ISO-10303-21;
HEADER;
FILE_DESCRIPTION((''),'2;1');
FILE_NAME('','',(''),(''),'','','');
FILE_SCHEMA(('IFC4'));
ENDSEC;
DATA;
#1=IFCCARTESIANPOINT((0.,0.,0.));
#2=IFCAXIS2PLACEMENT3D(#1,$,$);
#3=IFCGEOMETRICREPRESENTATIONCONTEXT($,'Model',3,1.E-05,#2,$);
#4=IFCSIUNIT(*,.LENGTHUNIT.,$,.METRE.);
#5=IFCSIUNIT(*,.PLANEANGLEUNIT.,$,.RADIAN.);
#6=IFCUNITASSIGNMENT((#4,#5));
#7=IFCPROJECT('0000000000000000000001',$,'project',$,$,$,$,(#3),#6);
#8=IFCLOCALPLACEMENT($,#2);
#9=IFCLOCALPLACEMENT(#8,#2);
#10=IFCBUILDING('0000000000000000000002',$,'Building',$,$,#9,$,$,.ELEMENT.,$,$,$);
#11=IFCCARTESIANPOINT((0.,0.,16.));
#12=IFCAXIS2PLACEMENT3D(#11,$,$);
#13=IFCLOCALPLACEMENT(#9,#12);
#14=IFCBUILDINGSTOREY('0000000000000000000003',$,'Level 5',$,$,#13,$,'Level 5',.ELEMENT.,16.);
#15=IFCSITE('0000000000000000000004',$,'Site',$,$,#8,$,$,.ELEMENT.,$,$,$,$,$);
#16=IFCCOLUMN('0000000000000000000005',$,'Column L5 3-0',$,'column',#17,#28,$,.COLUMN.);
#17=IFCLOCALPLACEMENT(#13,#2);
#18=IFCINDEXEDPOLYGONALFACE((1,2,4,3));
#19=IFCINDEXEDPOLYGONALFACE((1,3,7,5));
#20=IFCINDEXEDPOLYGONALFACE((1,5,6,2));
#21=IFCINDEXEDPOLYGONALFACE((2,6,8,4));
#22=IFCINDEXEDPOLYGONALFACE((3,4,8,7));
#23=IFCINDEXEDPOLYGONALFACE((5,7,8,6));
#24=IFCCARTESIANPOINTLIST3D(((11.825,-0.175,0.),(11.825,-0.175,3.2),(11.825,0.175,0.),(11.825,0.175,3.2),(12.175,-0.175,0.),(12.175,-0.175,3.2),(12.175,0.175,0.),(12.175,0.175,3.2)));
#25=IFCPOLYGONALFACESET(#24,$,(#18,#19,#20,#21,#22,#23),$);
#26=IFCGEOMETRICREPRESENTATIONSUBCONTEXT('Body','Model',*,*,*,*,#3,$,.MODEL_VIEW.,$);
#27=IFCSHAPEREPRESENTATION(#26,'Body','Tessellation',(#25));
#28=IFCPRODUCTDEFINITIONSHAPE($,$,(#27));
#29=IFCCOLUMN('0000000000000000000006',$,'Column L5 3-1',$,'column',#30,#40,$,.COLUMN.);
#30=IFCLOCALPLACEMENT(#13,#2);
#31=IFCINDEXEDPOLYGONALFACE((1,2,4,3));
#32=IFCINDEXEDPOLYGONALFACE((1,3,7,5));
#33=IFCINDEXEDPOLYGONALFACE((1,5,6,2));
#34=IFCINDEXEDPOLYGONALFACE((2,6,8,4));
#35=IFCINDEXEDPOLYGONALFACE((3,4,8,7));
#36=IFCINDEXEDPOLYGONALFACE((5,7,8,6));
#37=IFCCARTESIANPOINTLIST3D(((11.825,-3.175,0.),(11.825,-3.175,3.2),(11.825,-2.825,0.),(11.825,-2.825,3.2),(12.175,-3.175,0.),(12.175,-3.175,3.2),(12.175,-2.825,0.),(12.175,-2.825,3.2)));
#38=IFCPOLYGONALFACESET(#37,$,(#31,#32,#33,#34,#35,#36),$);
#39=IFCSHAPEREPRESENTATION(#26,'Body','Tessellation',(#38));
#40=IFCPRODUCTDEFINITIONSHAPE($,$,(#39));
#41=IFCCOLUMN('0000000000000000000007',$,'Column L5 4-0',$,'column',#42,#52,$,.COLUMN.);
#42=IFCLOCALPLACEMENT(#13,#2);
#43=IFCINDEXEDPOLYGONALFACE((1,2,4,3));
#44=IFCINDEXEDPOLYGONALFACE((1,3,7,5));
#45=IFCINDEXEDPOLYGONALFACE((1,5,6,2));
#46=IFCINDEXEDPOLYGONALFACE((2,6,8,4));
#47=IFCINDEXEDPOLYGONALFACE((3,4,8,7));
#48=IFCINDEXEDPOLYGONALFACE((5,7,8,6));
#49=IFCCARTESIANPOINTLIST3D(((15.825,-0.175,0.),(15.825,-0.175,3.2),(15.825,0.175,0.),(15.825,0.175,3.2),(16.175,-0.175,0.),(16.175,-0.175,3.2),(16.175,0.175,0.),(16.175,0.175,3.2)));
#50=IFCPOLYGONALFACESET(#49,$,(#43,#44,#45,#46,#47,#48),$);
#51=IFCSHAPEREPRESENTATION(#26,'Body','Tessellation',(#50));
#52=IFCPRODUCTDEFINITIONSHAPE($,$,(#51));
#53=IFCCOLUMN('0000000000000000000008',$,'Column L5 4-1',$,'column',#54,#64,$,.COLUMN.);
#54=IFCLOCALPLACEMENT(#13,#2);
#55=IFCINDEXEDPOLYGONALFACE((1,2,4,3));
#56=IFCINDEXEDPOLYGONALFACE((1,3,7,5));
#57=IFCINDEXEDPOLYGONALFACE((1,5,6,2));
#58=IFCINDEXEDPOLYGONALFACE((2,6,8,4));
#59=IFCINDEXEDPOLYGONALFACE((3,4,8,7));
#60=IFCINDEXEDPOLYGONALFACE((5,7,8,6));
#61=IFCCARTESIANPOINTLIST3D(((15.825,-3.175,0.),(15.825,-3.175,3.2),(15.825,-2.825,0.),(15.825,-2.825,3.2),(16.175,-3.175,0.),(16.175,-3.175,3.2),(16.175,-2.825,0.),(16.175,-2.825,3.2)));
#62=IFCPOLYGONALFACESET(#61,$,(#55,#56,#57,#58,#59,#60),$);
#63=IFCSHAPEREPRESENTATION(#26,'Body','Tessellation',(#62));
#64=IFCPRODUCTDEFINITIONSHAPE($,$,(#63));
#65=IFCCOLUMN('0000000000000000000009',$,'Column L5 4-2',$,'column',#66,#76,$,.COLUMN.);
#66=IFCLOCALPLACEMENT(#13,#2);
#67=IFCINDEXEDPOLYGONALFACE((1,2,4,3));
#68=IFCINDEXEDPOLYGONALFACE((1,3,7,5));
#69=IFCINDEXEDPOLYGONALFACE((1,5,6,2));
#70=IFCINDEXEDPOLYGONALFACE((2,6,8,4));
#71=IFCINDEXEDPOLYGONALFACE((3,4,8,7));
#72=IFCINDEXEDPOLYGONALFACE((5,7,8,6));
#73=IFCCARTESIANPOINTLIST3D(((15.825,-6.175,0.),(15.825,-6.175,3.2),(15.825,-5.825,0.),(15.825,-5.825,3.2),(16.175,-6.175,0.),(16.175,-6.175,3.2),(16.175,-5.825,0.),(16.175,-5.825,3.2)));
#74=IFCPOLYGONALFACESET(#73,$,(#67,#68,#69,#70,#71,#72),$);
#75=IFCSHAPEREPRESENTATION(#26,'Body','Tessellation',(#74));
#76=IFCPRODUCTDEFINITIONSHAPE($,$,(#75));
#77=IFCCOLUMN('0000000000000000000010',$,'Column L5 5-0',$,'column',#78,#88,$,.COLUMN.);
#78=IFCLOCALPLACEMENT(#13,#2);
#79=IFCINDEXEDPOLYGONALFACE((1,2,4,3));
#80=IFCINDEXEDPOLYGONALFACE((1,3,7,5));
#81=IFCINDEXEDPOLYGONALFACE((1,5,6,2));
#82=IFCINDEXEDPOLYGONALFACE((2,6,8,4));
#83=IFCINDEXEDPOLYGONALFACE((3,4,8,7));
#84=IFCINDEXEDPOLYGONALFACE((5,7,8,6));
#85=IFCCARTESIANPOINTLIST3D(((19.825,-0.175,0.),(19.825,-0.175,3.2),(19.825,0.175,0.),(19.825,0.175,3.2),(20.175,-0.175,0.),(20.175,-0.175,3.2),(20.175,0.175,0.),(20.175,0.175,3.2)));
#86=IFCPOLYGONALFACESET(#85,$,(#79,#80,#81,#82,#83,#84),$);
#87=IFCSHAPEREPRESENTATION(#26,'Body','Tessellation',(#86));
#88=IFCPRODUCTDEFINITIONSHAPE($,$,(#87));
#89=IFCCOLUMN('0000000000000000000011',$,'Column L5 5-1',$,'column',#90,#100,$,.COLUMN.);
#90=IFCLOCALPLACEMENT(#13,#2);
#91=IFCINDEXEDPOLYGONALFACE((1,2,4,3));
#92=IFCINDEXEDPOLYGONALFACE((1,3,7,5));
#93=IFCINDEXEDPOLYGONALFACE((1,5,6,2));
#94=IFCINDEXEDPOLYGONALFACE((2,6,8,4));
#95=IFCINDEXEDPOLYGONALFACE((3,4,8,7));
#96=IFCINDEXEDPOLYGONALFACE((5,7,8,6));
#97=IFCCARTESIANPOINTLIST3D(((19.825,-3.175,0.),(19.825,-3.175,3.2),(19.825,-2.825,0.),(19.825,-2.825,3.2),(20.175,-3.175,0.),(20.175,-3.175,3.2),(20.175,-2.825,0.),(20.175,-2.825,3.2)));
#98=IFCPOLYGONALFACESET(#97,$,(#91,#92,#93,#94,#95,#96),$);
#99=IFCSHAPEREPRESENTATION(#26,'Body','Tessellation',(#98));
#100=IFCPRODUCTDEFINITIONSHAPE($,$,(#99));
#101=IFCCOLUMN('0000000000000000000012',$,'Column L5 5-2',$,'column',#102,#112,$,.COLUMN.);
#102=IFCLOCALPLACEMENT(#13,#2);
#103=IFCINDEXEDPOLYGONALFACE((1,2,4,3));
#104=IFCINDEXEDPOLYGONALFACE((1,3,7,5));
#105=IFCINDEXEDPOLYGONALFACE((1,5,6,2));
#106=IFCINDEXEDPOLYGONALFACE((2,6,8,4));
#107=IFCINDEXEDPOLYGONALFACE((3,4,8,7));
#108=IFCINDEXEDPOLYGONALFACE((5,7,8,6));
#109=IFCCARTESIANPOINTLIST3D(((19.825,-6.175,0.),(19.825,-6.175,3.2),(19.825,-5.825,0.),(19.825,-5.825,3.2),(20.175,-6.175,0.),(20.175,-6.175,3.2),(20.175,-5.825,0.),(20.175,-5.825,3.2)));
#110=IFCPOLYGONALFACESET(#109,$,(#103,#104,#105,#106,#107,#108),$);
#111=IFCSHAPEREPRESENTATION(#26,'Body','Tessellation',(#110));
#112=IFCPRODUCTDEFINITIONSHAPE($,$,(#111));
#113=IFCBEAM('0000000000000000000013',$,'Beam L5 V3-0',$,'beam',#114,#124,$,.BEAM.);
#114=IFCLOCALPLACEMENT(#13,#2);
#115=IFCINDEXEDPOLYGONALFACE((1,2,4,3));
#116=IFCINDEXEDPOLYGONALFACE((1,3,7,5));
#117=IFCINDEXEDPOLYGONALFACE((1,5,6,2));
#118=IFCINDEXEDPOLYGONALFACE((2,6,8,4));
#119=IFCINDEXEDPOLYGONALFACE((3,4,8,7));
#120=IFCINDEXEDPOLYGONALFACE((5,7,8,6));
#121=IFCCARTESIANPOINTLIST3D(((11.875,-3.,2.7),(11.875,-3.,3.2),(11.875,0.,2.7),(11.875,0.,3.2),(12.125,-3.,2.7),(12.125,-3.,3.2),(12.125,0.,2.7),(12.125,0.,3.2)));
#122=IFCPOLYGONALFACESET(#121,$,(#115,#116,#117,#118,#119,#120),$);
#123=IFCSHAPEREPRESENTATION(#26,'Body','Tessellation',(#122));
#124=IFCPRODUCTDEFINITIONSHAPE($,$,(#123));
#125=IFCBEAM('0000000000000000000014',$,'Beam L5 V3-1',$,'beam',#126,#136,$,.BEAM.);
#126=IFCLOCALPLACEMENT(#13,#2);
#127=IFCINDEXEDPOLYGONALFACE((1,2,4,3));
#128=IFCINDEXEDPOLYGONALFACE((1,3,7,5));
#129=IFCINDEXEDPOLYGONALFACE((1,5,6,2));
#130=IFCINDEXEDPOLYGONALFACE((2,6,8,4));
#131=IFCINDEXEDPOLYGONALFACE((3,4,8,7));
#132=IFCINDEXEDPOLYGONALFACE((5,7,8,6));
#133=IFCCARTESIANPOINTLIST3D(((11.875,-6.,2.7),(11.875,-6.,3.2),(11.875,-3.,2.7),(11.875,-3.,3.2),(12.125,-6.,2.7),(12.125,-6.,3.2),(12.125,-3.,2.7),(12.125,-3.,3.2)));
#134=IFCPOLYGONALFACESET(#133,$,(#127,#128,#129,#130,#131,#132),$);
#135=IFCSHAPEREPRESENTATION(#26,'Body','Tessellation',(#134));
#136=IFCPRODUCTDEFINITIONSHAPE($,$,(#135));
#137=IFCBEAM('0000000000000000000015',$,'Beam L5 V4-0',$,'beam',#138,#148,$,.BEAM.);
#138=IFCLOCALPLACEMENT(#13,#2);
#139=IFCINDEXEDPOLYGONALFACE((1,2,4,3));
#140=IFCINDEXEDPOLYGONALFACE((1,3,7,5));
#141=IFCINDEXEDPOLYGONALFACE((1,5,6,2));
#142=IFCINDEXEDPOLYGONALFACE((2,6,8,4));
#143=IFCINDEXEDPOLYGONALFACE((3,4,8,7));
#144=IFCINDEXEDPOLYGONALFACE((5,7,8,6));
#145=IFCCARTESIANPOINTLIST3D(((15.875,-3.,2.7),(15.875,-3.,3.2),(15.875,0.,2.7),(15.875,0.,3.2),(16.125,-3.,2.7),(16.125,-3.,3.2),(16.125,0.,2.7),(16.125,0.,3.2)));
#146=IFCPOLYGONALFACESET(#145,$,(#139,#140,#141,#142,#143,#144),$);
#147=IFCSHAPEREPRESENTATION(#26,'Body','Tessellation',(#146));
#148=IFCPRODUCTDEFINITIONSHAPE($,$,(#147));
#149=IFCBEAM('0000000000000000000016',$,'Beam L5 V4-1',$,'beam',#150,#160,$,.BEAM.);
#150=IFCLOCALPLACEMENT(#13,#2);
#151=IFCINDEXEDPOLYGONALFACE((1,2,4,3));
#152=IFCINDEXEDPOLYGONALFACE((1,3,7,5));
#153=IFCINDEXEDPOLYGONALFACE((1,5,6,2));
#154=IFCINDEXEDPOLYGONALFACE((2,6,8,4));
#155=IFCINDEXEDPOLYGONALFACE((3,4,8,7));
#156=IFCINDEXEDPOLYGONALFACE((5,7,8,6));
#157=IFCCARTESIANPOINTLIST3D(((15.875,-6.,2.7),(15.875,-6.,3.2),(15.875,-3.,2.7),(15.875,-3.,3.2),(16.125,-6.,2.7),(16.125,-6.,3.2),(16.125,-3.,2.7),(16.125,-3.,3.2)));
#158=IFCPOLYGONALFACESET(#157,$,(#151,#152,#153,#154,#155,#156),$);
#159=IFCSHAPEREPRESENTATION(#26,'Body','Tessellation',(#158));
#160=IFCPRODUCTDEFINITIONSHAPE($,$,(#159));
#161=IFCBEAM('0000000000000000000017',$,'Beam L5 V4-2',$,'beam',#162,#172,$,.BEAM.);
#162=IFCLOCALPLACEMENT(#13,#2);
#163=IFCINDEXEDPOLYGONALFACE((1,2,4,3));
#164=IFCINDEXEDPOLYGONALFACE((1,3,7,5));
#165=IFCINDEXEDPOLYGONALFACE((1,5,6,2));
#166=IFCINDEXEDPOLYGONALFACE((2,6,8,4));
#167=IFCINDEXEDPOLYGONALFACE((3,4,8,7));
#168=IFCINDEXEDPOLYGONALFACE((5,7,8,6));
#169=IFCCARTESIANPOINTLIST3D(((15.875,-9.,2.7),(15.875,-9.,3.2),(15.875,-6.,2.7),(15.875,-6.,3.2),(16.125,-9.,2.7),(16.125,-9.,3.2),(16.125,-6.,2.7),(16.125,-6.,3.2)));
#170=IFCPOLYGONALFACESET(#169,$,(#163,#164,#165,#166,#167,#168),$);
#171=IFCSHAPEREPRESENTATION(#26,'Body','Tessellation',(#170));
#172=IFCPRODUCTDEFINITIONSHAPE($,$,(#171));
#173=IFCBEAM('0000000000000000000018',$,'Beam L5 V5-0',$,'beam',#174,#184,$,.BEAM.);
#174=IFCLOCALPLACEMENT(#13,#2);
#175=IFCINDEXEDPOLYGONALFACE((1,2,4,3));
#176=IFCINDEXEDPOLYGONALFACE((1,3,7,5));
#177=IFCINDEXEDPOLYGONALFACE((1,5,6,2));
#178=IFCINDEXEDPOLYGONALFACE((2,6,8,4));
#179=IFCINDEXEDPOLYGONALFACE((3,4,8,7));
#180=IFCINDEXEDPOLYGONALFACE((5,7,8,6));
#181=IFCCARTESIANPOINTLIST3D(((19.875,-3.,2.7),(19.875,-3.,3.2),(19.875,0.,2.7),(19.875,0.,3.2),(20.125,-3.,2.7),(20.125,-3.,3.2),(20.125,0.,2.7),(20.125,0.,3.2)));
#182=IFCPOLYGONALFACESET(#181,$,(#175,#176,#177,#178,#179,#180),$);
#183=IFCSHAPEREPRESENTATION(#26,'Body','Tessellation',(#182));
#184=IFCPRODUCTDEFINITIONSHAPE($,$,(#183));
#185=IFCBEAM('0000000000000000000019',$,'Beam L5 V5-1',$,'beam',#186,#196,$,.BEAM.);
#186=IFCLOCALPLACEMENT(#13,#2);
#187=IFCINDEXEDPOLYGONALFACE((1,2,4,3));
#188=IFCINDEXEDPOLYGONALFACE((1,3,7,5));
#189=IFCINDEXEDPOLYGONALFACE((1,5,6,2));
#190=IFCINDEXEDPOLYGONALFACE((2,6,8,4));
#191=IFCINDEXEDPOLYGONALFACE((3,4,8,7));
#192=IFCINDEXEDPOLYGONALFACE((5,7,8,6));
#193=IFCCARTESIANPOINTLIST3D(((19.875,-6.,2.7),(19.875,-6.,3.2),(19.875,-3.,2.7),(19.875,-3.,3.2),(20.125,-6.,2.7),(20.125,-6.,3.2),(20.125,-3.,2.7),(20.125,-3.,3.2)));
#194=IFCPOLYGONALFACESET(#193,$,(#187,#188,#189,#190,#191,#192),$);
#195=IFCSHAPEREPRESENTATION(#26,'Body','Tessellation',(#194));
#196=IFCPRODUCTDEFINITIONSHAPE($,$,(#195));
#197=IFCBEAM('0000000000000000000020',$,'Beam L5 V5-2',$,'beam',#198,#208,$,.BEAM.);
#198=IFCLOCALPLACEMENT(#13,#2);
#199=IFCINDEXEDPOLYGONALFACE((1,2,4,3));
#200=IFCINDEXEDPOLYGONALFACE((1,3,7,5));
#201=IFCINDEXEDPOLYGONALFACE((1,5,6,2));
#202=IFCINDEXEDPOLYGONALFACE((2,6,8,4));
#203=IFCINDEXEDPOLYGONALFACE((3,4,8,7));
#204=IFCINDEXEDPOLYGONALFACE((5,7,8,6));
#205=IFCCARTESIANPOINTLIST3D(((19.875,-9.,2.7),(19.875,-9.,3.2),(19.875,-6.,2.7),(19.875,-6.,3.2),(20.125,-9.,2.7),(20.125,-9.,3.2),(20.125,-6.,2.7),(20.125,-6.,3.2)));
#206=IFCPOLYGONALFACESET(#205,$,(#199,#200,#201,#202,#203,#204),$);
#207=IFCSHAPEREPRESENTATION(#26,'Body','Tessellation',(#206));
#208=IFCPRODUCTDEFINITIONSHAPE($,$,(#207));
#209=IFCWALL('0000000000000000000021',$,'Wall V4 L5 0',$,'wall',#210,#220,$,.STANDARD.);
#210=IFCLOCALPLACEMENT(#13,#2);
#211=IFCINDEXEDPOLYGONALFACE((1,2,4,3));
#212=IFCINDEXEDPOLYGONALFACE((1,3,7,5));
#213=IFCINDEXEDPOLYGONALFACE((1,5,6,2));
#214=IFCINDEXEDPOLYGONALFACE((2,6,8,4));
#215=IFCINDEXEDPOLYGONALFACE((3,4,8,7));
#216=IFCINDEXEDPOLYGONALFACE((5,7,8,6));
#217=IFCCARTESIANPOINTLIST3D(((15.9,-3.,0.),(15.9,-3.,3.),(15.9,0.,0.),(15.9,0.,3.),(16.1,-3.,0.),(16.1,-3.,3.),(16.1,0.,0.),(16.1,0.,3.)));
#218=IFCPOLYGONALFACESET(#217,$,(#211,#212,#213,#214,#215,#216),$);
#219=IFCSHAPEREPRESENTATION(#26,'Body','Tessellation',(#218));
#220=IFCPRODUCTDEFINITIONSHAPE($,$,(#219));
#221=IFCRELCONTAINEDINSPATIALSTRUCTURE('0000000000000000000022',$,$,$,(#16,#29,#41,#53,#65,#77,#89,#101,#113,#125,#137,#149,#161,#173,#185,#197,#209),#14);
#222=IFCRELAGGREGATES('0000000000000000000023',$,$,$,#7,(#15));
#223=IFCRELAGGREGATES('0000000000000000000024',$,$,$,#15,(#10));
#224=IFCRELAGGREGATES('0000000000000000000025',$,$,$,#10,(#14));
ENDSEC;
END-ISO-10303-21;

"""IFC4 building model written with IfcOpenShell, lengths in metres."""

from ifc_helpers import new_model, si_unit, frame, frame_2d, origin, origin_2d, place, context, subcontext, project, spatial, rectangle, extrude, element, save


model = new_model("IFC4")

# Units and contexts
model_context = context("Model", 3, precision=1e-05, world=origin())
body_context = subcontext(model_context, "Body", "Model", "MODEL_VIEW")
ifc_project = project(units=[si_unit("LENGTHUNIT", "METRE"), si_unit("PLANEANGLEUNIT", "RADIAN")], contexts=[model_context])

# Site, building, storey
site_placement = place(None, origin())
site = spatial("IfcSite", under=ifc_project, at=site_placement, Name="Site", CompositionType="ELEMENT")
building_placement = place(site_placement, origin())
building = spatial("IfcBuilding", under=site, at=building_placement, Name="Building", CompositionType="ELEMENT")
storey_placement = place(building_placement, frame((0.0, 0.0, 16.0)))
storey = spatial("IfcBuildingStorey", under=building, at=storey_placement, Name="Level 5", LongName="Level 5", CompositionType="ELEMENT", Elevation=16.0)

# Columns
for number, where, name in (
    (1, (12.0, 0.0, 0.0), "Column L5 3-0"),
    (2, (12.0, -3.0, 0.0), "Column L5 3-1"),
    (3, (16.0, 0.0, 0.0), "Column L5 4-0"),
    (4, (16.0, -3.0, 0.0), "Column L5 4-1"),
    (5, (16.0, -6.0, 0.0), "Column L5 4-2"),
    (6, (20.0, 0.0, 0.0), "Column L5 5-0"),
    (7, (20.0, -3.0, 0.0), "Column L5 5-1"),
    (8, (20.0, -6.0, 0.0), "Column L5 5-2"),
):
    element("IfcColumn", number, at=place(storey_placement, frame(where)), inside=storey, Name=name, ObjectType="column", PredefinedType="COLUMN", context=body_context, shape_type="SweptSolid", body=[
        extrude(rectangle(XDim=0.35, YDim=0.35, at=origin_2d()), origin(), (0.0, 0.0, 1.0), 3.2),
    ])

# Beams
for number, where, z_axis, x_axis, name in (
    (9, (12.0, 0.0, 2.95), (0.0, -1.0, 0.0), (0.0, 0.0, 1.0), "Beam L5 V3-0"),
    (10, (12.0, -3.0, 2.95), (0.0, -1.0, 0.0), (0.0, 0.0, 1.0), "Beam L5 V3-1"),
    (11, (16.0, 0.0, 2.95), (0.0, -1.0, 0.0), (0.0, 0.0, 1.0), "Beam L5 V4-0"),
    (12, (16.0, -3.0, 2.95), (0.0, -1.0, 0.0), (0.0, 0.0, 1.0), "Beam L5 V4-1"),
    (13, (16.0, -6.0, 2.95), (0.0, -1.0, 0.0), (0.0, 0.0, 1.0), "Beam L5 V4-2"),
    (14, (20.0, 0.0, 2.95), (0.0, -1.0, 0.0), (0.0, 0.0, 1.0), "Beam L5 V5-0"),
    (15, (20.0, -3.0, 2.95), (0.0, -1.0, 0.0), (0.0, 0.0, 1.0), "Beam L5 V5-1"),
    (16, (20.0, -6.0, 2.95), (0.0, -1.0, 0.0), (0.0, 0.0, 1.0), "Beam L5 V5-2"),
):
    element("IfcBeam", number, at=place(storey_placement, frame(where, z_axis=z_axis, x_axis=x_axis)), inside=storey, Name=name, ObjectType="beam", PredefinedType="BEAM", context=body_context, shape_type="SweptSolid", body=[
        extrude(rectangle(XDim=0.5, YDim=0.25, at=origin_2d()), origin(), (0.0, 0.0, 1.0), 3.0),
    ])

# Wall
wall_1_placement = place(storey_placement, frame((16.0, 0.0, 0.0), z_axis=(0.0, 0.0, 1.0), x_axis=(0.0, -1.0, 0.0)))
element("IfcWall", 17, at=wall_1_placement, inside=storey, Name="Wall V4 L5 0", ObjectType="wall", PredefinedType="STANDARD", context=body_context, shape_type="SweptSolid", body=[
    extrude(rectangle(XDim=3.0, YDim=0.2, at=frame_2d((1.5, 0.0))), origin(), (0.0, 0.0, 1.0), 3.0),
])

save(model, "model.ifc")
